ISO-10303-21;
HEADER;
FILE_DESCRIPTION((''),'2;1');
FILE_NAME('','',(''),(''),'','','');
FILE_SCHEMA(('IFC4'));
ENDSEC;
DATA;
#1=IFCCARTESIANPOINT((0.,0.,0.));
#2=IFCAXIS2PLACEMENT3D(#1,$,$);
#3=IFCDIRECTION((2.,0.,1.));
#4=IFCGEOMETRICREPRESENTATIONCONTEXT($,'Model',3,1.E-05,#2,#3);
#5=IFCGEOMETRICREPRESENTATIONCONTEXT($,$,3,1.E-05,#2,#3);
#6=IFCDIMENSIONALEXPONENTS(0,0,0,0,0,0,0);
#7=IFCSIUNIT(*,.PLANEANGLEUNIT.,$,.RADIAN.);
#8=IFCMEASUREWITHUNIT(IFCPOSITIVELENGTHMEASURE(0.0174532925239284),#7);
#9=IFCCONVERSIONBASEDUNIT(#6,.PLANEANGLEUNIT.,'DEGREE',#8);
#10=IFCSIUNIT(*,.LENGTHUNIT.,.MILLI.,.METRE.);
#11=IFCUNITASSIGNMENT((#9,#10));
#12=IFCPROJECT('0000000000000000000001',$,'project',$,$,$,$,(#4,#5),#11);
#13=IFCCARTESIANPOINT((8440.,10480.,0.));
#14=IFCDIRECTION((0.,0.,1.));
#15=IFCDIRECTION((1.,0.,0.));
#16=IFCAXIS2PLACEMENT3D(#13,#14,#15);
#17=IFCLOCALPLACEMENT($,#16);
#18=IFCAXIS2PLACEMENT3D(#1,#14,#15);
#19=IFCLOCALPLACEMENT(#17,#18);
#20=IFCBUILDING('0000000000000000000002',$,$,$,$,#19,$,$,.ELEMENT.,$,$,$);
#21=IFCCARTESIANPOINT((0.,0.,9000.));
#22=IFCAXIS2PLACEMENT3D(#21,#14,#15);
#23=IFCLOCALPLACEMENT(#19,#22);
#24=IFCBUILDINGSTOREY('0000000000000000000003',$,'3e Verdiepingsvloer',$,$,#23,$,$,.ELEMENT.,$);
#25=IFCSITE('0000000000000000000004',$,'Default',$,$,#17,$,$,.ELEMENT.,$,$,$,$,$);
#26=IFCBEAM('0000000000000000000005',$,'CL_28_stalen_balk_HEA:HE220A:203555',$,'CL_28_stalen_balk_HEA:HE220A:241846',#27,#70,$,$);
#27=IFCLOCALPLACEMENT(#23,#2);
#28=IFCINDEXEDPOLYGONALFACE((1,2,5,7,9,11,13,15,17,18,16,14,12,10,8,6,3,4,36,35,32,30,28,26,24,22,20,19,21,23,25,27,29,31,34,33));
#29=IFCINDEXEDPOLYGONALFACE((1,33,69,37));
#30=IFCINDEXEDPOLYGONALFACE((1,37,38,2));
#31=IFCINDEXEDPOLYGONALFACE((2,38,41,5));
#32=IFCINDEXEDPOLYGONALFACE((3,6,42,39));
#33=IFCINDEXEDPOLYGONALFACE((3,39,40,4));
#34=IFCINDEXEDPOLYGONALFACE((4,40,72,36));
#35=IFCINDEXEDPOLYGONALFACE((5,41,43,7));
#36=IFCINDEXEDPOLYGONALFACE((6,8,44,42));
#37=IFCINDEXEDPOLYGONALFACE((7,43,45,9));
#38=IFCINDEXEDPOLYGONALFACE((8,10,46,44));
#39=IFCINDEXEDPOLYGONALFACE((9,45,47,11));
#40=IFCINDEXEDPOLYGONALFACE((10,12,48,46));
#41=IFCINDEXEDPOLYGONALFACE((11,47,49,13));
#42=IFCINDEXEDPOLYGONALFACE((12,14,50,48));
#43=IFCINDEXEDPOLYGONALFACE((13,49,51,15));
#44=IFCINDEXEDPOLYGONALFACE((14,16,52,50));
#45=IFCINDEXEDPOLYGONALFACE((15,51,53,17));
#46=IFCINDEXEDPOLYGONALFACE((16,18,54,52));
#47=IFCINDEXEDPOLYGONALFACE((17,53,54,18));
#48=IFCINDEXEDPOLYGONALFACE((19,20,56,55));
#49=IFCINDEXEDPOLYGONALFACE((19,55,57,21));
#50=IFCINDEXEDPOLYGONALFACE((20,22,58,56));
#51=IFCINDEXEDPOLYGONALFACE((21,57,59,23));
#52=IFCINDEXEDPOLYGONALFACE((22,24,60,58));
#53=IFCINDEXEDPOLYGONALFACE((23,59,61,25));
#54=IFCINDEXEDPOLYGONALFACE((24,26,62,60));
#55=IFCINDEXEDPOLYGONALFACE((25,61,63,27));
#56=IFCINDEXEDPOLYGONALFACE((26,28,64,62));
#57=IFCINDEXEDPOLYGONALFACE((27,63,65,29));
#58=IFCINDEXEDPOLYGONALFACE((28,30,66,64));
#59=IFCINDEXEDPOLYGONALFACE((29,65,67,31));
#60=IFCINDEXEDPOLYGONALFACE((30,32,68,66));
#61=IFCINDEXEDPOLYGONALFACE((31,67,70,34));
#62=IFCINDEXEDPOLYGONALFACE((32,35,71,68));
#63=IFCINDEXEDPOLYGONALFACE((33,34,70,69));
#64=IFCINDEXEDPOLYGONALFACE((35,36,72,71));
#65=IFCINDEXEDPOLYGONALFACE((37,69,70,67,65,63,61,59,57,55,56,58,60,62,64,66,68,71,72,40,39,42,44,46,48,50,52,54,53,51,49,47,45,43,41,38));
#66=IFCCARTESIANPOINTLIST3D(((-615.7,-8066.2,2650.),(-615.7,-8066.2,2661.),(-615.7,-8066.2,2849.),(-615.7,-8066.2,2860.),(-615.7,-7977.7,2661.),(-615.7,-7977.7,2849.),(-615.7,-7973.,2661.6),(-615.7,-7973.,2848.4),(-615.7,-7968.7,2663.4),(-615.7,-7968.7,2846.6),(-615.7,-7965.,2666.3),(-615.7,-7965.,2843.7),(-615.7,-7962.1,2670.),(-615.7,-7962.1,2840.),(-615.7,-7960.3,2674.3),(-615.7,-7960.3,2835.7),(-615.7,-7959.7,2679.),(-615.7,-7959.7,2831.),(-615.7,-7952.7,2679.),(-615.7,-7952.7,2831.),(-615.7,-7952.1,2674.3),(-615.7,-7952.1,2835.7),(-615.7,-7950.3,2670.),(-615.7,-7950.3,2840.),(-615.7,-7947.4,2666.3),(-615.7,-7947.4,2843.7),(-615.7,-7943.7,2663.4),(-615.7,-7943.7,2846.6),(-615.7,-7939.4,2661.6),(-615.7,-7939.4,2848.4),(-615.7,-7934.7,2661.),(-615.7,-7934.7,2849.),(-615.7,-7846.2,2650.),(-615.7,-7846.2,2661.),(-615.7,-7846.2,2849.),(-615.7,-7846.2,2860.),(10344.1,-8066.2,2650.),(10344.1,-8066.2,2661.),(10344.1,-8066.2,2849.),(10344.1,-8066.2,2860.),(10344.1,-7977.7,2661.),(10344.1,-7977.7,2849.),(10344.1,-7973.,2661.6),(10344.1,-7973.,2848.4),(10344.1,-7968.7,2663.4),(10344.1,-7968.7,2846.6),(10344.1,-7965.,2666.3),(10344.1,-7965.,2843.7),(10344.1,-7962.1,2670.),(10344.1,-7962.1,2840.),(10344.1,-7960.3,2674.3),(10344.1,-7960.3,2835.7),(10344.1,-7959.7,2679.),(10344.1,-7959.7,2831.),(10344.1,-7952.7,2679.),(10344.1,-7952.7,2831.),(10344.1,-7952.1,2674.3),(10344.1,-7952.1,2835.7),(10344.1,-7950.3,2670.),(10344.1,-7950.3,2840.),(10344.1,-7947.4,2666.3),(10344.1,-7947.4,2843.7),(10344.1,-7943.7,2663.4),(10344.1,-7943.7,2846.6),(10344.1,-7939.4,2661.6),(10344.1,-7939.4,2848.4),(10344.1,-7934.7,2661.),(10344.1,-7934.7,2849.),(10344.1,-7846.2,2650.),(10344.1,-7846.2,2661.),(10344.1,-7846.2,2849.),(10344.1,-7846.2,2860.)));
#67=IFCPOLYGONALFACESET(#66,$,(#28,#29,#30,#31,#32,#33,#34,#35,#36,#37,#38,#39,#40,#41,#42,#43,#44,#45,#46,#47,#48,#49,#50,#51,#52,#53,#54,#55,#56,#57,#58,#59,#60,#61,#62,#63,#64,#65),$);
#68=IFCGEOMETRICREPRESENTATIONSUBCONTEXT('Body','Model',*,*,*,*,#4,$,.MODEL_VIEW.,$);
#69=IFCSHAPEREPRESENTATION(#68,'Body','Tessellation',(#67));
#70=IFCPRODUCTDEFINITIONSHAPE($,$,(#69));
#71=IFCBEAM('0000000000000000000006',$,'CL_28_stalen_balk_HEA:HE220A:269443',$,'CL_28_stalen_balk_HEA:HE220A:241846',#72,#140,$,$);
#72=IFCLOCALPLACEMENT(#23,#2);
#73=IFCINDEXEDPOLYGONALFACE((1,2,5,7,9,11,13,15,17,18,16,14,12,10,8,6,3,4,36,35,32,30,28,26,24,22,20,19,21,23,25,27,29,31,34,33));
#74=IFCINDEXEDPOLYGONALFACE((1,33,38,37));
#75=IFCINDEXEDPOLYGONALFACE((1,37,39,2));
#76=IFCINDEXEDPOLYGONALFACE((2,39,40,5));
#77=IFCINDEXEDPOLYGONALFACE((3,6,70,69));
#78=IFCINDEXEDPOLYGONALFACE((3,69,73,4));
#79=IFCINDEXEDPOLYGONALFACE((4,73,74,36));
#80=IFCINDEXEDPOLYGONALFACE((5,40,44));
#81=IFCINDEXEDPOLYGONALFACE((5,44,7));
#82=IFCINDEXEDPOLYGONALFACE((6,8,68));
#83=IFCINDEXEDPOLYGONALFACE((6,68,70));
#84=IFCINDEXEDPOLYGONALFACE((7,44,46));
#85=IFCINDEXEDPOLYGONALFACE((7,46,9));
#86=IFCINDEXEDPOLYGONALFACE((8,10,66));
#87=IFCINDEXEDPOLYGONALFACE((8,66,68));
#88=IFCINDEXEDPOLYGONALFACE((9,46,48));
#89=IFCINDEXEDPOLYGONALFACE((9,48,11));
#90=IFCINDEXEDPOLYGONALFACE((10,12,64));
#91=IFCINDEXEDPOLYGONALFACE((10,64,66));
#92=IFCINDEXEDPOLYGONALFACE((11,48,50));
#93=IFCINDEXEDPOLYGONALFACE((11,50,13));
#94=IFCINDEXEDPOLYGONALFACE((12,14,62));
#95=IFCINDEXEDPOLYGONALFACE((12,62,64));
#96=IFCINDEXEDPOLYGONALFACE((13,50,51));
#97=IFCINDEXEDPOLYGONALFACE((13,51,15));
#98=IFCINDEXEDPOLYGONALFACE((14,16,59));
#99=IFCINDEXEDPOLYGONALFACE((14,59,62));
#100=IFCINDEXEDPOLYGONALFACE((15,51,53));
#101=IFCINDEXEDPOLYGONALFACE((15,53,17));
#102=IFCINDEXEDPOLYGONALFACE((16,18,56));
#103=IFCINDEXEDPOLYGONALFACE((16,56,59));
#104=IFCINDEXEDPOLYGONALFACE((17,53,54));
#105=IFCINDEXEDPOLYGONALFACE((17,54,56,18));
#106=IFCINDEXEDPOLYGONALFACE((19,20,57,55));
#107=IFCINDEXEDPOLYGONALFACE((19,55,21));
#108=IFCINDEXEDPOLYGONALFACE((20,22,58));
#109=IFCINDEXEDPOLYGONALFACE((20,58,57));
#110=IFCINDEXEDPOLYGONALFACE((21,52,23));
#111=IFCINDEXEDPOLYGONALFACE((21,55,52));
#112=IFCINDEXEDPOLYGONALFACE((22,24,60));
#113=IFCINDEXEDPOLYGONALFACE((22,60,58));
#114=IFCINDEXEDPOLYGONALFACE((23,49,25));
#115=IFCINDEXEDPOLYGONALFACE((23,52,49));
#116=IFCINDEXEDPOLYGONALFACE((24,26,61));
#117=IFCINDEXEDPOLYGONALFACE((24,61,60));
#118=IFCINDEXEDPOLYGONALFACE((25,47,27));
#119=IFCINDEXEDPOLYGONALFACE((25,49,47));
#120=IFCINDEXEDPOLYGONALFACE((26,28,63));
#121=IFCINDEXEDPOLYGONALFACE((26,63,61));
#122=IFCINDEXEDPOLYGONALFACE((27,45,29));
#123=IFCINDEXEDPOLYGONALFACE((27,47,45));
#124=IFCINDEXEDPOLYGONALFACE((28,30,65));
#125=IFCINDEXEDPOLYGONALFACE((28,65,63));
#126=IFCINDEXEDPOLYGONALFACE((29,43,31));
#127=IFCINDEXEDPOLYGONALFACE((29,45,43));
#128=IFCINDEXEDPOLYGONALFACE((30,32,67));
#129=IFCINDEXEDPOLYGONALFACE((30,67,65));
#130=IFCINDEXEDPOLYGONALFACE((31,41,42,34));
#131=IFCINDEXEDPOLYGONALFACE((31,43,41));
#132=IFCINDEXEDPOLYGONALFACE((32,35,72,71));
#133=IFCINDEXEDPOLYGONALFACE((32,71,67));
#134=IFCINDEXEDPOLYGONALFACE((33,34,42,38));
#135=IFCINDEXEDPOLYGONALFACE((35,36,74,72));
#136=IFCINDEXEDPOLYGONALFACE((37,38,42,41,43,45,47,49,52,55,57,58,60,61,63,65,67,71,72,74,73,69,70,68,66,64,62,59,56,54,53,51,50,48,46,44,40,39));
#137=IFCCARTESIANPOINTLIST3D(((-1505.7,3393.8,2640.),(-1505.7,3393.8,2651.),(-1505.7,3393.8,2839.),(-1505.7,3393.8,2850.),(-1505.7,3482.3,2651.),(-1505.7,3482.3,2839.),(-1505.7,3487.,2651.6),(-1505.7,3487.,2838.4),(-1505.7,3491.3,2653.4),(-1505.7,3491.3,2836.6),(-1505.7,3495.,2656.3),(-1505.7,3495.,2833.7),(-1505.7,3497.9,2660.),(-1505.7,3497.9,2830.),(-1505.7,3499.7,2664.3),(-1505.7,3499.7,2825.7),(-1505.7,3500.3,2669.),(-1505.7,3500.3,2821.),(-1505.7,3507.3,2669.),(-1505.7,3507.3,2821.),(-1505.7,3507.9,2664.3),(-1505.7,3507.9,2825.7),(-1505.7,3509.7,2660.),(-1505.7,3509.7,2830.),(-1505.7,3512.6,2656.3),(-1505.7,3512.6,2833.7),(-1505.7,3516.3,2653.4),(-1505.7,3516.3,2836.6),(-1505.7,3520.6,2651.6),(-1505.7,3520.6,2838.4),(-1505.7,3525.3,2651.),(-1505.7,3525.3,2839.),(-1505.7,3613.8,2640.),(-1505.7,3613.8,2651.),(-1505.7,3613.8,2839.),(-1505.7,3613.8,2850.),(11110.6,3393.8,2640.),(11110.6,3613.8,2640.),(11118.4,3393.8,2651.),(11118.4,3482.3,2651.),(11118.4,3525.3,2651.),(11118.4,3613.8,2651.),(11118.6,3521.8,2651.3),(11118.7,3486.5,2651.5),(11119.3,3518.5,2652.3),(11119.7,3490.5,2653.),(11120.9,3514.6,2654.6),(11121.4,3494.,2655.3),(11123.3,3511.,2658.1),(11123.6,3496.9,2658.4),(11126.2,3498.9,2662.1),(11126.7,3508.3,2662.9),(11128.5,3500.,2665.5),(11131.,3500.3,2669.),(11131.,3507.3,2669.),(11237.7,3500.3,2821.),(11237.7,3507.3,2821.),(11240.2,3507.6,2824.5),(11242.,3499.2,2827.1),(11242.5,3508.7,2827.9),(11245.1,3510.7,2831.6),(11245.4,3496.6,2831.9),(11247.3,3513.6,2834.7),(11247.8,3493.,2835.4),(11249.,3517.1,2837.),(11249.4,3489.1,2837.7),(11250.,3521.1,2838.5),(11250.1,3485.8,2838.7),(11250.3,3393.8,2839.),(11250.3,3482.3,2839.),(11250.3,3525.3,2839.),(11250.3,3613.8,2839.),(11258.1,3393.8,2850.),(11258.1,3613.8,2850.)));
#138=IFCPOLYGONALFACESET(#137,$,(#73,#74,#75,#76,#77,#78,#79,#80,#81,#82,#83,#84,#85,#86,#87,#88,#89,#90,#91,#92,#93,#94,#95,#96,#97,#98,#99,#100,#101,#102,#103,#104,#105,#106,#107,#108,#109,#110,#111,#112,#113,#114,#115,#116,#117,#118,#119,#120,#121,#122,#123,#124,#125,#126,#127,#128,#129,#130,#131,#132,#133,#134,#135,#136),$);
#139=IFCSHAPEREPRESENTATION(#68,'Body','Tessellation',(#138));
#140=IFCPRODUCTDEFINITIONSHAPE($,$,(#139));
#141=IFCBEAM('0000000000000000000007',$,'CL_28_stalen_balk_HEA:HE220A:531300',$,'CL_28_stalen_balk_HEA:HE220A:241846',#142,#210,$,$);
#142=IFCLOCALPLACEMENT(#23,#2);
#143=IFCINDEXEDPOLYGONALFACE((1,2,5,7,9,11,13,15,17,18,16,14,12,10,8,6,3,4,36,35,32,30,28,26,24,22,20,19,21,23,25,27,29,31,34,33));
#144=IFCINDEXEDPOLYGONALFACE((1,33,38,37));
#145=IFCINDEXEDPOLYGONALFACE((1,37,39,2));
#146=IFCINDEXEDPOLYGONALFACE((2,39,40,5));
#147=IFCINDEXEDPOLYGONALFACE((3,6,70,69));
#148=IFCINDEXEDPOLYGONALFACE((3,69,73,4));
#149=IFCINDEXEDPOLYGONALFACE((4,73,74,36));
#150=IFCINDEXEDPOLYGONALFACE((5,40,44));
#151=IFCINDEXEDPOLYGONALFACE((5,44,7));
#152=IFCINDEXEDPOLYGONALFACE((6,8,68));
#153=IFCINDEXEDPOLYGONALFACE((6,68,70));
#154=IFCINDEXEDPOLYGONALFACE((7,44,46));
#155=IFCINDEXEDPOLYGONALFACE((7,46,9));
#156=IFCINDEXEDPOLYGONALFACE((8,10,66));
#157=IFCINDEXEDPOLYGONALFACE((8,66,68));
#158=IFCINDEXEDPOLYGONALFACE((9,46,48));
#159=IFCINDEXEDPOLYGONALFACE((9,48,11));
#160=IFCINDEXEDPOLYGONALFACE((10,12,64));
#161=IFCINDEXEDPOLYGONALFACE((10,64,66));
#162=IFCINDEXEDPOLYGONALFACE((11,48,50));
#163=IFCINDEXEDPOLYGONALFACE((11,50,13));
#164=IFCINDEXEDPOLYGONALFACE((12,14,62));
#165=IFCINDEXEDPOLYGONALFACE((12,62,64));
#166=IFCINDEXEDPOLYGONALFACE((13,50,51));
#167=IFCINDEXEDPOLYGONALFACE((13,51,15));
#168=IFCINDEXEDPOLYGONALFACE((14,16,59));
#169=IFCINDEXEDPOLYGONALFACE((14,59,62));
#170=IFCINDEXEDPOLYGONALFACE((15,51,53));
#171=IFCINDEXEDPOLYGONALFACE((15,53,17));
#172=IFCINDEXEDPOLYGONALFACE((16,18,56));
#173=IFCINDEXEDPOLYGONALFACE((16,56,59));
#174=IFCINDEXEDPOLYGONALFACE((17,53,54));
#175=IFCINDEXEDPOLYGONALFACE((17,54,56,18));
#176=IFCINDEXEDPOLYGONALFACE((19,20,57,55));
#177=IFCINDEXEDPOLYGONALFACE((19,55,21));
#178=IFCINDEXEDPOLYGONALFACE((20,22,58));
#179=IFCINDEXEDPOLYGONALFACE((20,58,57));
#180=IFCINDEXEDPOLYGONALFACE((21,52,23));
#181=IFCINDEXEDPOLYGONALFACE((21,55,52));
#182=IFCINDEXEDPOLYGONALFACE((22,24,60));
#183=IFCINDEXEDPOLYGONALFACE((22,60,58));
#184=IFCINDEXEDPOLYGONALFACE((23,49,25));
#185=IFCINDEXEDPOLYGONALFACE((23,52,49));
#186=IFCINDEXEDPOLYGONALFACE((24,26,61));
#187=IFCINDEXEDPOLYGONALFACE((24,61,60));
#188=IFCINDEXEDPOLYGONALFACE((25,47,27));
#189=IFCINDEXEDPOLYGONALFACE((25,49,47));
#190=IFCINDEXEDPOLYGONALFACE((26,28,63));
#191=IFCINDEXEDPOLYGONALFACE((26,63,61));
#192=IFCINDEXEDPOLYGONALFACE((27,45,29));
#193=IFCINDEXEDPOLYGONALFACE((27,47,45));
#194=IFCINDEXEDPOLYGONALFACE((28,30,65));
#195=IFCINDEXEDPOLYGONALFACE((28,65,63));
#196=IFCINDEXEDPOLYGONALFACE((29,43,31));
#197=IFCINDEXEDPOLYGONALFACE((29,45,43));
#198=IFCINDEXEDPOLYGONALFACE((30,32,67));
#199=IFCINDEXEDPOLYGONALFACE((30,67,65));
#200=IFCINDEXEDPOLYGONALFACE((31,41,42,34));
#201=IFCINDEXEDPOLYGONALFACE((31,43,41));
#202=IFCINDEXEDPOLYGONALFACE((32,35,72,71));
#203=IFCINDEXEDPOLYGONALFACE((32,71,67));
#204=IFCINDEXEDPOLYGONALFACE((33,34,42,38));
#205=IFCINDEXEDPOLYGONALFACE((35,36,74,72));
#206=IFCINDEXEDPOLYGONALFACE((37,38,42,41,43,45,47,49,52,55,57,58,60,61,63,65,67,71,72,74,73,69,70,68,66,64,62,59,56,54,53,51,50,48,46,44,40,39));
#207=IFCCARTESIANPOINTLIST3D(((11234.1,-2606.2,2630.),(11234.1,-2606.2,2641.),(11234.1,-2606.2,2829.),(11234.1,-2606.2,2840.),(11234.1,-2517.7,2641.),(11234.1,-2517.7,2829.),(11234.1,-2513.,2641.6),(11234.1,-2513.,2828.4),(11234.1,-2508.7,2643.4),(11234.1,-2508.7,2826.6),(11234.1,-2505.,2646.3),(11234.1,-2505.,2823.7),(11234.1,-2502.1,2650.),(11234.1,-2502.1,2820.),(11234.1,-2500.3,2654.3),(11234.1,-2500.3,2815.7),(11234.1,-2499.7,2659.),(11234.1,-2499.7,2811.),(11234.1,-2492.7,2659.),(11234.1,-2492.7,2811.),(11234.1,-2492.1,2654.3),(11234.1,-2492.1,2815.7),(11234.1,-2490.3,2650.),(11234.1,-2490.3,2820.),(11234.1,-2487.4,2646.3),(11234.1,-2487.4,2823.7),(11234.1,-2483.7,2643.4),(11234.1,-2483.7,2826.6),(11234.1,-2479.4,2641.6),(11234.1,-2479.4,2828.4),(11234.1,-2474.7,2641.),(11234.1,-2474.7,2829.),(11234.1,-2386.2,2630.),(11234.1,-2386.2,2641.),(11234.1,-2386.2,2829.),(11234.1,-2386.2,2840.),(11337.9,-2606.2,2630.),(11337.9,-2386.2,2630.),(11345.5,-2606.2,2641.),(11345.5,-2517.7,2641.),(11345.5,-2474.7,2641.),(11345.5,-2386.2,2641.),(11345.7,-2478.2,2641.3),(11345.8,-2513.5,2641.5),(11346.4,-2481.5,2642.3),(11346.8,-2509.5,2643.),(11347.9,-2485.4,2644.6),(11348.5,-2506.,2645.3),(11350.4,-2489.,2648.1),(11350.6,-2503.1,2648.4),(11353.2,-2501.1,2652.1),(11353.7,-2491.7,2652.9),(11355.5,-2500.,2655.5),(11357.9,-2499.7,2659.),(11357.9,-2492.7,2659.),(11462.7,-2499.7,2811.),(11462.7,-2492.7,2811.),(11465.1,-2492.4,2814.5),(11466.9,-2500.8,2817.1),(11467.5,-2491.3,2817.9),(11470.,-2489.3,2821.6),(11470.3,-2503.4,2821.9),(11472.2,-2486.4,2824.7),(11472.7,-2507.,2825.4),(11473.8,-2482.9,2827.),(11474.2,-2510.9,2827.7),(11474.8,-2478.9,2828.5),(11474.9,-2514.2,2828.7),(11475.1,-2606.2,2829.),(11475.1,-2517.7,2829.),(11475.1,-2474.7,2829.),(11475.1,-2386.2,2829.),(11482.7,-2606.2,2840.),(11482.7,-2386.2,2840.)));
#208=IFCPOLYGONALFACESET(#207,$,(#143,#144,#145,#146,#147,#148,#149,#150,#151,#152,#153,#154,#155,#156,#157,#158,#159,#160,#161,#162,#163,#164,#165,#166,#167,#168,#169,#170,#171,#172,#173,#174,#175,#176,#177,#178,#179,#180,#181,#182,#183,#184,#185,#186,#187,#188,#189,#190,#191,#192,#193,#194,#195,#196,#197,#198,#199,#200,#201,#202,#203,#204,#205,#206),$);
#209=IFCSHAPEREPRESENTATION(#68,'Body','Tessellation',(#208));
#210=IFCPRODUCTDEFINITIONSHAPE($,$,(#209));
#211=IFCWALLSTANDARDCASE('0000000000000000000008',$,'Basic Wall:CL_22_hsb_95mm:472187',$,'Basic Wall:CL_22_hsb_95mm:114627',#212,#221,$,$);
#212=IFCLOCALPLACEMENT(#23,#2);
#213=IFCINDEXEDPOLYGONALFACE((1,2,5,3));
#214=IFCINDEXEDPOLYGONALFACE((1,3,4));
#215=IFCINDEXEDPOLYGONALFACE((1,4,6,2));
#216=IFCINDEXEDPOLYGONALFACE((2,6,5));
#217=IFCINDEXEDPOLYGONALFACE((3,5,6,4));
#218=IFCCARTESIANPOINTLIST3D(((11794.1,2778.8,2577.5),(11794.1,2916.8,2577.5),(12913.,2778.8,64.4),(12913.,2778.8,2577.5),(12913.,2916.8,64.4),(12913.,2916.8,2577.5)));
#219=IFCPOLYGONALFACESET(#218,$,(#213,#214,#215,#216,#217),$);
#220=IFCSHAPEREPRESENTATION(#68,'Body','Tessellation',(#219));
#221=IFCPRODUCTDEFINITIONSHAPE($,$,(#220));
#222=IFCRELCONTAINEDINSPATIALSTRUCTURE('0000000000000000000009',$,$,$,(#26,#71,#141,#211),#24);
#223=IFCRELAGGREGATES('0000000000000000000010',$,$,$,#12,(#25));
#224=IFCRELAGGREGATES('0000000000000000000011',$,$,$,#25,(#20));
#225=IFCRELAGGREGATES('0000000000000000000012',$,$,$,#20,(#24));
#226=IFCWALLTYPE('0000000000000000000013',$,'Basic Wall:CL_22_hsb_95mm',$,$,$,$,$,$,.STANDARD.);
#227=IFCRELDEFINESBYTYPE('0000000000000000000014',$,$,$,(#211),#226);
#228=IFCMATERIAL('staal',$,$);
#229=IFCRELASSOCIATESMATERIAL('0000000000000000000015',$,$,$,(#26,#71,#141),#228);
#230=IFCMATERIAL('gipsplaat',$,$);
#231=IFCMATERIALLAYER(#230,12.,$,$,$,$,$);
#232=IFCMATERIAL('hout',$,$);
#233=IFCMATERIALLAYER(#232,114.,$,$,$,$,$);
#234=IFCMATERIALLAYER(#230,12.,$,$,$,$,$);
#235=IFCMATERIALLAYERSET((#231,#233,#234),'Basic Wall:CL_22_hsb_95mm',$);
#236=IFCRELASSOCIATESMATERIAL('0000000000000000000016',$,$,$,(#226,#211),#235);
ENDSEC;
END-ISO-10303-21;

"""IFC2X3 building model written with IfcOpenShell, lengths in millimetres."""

from ifc_helpers import new_model, entity, si_unit, converted_unit, direction, frame, frame_2d, origin, origin_with_axes, place, context, subcontext, project, spatial, rectangle, i_section, extrude, clip, halfspace, source, transform, mapped, material, layer, layer_set, layer_usage, type_object, element, save


model = new_model("IFC2X3")

# Units and contexts
model_context = context("Model", 3, precision=1e-05, world=origin(), true_north=direction((2.0, 0.0, 1.0)))
context_of_model = context(None, 3, precision=1e-05, world=origin(), true_north=direction((2.0, 0.0, 1.0)))
body_context = subcontext(model_context, "Body", "Model", "MODEL_VIEW")
ifc_project = project(units=[converted_unit("PLANEANGLEUNIT", "DEGREE", entity("IfcPositiveLengthMeasure", 0.0174532925239284), si_unit("PLANEANGLEUNIT", "RADIAN"), dimensions=[0, 0, 0, 0, 0, 0, 0]), si_unit("LENGTHUNIT", "METRE", prefix="MILLI")], contexts=[model_context, context_of_model])

# Site, building, storey
site_placement = place(None, frame((8440.0, 10480.0, 0.0), z_axis=(0.0, 0.0, 1.0), x_axis=(1.0, 0.0, 0.0)))
site = spatial("IfcSite", under=ifc_project, at=site_placement, Name="Default", CompositionType="ELEMENT")
building_placement = place(site_placement, origin_with_axes())
building = spatial("IfcBuilding", under=site, at=building_placement, CompositionType="ELEMENT")
storey_placement = place(building_placement, frame((0.0, 0.0, 9000.0), z_axis=(0.0, 0.0, 1.0), x_axis=(1.0, 0.0, 0.0)))
storey = spatial("IfcBuildingStorey", under=building, at=storey_placement, Name="3e Verdiepingsvloer", CompositionType="ELEMENT")

# Beams
ifc_material_1 = material(Name="staal")
ifc_material_2 = material(Name="hout")
beam_1_placement = place(storey_placement, frame((10764.1, -7956.2, 2860.0), z_axis=(0.0, 0.0, 1.0), x_axis=(-1.0, 0.0, 0.0)))
element("IfcBeam", 1, at=beam_1_placement, inside=storey, material=ifc_material_1, Name="CL_28_stalen_balk_HEA:HE220A:203555", ObjectType="CL_28_stalen_balk_HEA:HE220A:241846", context=body_context, shape_type="SweptSolid", body=[
    extrude(i_section(OverallWidth=220.0, OverallDepth=210.0, WebThickness=7.0, FlangeThickness=11.0, FilletRadius=18.0, at=frame_2d((0.0, 0.0), x_axis=(0.0, 1.0))), frame((420.0, 0.0, -105.0), z_axis=(1.0, 0.0, 0.0), x_axis=(0.0, 0.0, -1.0)), (0.0, 0.0, 1.0), 10959.8),
])
beam_2_placement = place(storey_placement, frame((11704.1, 3503.8, 2850.0), z_axis=(0.0, 0.0, 1.0), x_axis=(-1.0, 0.0, 0.0)))
element("IfcBeam", 2, at=beam_2_placement, inside=storey, material=ifc_material_1, Name="CL_28_stalen_balk_HEA:HE220A:269443", ObjectType="CL_28_stalen_balk_HEA:HE220A:241846", context=body_context, shape_type="Clipping", body=[
    clip(extrude(i_section(OverallWidth=220.0, OverallDepth=210.0, WebThickness=7.0, FlangeThickness=11.0, FilletRadius=18.0, at=frame_2d((0.0, 0.0), x_axis=(0.0, 1.0))), frame((446.0, 0.0, -105.0), z_axis=(1.0, 0.0, 0.0), x_axis=(0.0, 0.0, -1.0)), (0.0, 0.0, 1.0), 12763.8), halfspace(frame((446.0, -2115.1, 0.0), z_axis=(-0.818469, 0.0, -0.574551), x_axis=(-0.574551, 0.0, 0.818469)), False)),
])
beam_3_placement = place(storey_placement, frame((11964.1, -2496.2, 2840.0), z_axis=(0.0, 0.0, 1.0), x_axis=(-1.0, 0.0, 0.0)))
element("IfcBeam", 3, at=beam_3_placement, inside=storey, material=ifc_material_1, Name="CL_28_stalen_balk_HEA:HE220A:531300", ObjectType="CL_28_stalen_balk_HEA:HE220A:241846", context=body_context, shape_type="Clipping", body=[
    clip(extrude(i_section(OverallWidth=220.0, OverallDepth=210.0, WebThickness=7.0, FlangeThickness=11.0, FilletRadius=18.0, at=frame_2d((0.0, 0.0), x_axis=(0.0, 1.0))), frame((481.4, 0.0, -105.0), z_axis=(1.0, 0.0, 0.0), x_axis=(0.0, 0.0, -1.0)), (0.0, 0.0, 1.0), 248.7), halfspace(frame((474.5, -667.6, 10.0), z_axis=(-0.823229, 0.0, -0.567709), x_axis=(-0.567709, 0.0, 0.823229)), False)),
])

# Wall
ifc_material_3 = material(Name="gipsplaat")
ifc_layer_1 = layer(ifc_material_3, 12.0)
ifc_layer_2 = layer(ifc_material_2, 114.0)
ifc_layer_3 = layer(ifc_material_3, 12.0)
ifc_layer_set_1 = layer_set([ifc_layer_1, ifc_layer_2, ifc_layer_3], Name="Basic Wall:CL_22_hsb_95mm")
ifc_layer_usage_1 = layer_usage(ifc_layer_set_1, "AXIS2", "NEGATIVE", 69.0)
wall_type_1 = type_object("IfcWallType", Name="Basic Wall:CL_22_hsb_95mm", PredefinedType="STANDARD", material=ifc_layer_set_1)
shared_shape_1 = source(origin(), body_context, "Body", "Clipping", [
    clip(clip(extrude(rectangle(XDim=1118.9, YDim=138.0, at=frame_2d((559.5, 0.0), x_axis=(-1.0, 0.0))), origin(), (0.0, 0.0, 1.0), 2860.0), halfspace(frame((1118.9, -69.0, 64.4), z_axis=(-0.913545, 0.0, -0.406737), x_axis=(0.0, 1.0, 0.0)), False)), halfspace(frame((0.0, -69.0, 2577.5), z_axis=(0.0, 0.0, 1.0), x_axis=(0.0, 1.0, 0.0)), False)),
])
wall_1_placement = place(storey_placement, frame((11794.1, 2847.8, 0.0), z_axis=(0.0, 0.0, 1.0), x_axis=(1.0, 0.0, 0.0)))
element("IfcWallStandardCase", 4, at=wall_1_placement, inside=storey, type_object=wall_type_1, material=ifc_layer_usage_1, Name="Basic Wall:CL_22_hsb_95mm:472187", ObjectType="Basic Wall:CL_22_hsb_95mm:114627", context=body_context, shape_type="MappedRepresentation", body=[
    mapped(shared_shape_1, transform((0.0, 0.0, 0.0))),
])

save(model, "model.ifc")
